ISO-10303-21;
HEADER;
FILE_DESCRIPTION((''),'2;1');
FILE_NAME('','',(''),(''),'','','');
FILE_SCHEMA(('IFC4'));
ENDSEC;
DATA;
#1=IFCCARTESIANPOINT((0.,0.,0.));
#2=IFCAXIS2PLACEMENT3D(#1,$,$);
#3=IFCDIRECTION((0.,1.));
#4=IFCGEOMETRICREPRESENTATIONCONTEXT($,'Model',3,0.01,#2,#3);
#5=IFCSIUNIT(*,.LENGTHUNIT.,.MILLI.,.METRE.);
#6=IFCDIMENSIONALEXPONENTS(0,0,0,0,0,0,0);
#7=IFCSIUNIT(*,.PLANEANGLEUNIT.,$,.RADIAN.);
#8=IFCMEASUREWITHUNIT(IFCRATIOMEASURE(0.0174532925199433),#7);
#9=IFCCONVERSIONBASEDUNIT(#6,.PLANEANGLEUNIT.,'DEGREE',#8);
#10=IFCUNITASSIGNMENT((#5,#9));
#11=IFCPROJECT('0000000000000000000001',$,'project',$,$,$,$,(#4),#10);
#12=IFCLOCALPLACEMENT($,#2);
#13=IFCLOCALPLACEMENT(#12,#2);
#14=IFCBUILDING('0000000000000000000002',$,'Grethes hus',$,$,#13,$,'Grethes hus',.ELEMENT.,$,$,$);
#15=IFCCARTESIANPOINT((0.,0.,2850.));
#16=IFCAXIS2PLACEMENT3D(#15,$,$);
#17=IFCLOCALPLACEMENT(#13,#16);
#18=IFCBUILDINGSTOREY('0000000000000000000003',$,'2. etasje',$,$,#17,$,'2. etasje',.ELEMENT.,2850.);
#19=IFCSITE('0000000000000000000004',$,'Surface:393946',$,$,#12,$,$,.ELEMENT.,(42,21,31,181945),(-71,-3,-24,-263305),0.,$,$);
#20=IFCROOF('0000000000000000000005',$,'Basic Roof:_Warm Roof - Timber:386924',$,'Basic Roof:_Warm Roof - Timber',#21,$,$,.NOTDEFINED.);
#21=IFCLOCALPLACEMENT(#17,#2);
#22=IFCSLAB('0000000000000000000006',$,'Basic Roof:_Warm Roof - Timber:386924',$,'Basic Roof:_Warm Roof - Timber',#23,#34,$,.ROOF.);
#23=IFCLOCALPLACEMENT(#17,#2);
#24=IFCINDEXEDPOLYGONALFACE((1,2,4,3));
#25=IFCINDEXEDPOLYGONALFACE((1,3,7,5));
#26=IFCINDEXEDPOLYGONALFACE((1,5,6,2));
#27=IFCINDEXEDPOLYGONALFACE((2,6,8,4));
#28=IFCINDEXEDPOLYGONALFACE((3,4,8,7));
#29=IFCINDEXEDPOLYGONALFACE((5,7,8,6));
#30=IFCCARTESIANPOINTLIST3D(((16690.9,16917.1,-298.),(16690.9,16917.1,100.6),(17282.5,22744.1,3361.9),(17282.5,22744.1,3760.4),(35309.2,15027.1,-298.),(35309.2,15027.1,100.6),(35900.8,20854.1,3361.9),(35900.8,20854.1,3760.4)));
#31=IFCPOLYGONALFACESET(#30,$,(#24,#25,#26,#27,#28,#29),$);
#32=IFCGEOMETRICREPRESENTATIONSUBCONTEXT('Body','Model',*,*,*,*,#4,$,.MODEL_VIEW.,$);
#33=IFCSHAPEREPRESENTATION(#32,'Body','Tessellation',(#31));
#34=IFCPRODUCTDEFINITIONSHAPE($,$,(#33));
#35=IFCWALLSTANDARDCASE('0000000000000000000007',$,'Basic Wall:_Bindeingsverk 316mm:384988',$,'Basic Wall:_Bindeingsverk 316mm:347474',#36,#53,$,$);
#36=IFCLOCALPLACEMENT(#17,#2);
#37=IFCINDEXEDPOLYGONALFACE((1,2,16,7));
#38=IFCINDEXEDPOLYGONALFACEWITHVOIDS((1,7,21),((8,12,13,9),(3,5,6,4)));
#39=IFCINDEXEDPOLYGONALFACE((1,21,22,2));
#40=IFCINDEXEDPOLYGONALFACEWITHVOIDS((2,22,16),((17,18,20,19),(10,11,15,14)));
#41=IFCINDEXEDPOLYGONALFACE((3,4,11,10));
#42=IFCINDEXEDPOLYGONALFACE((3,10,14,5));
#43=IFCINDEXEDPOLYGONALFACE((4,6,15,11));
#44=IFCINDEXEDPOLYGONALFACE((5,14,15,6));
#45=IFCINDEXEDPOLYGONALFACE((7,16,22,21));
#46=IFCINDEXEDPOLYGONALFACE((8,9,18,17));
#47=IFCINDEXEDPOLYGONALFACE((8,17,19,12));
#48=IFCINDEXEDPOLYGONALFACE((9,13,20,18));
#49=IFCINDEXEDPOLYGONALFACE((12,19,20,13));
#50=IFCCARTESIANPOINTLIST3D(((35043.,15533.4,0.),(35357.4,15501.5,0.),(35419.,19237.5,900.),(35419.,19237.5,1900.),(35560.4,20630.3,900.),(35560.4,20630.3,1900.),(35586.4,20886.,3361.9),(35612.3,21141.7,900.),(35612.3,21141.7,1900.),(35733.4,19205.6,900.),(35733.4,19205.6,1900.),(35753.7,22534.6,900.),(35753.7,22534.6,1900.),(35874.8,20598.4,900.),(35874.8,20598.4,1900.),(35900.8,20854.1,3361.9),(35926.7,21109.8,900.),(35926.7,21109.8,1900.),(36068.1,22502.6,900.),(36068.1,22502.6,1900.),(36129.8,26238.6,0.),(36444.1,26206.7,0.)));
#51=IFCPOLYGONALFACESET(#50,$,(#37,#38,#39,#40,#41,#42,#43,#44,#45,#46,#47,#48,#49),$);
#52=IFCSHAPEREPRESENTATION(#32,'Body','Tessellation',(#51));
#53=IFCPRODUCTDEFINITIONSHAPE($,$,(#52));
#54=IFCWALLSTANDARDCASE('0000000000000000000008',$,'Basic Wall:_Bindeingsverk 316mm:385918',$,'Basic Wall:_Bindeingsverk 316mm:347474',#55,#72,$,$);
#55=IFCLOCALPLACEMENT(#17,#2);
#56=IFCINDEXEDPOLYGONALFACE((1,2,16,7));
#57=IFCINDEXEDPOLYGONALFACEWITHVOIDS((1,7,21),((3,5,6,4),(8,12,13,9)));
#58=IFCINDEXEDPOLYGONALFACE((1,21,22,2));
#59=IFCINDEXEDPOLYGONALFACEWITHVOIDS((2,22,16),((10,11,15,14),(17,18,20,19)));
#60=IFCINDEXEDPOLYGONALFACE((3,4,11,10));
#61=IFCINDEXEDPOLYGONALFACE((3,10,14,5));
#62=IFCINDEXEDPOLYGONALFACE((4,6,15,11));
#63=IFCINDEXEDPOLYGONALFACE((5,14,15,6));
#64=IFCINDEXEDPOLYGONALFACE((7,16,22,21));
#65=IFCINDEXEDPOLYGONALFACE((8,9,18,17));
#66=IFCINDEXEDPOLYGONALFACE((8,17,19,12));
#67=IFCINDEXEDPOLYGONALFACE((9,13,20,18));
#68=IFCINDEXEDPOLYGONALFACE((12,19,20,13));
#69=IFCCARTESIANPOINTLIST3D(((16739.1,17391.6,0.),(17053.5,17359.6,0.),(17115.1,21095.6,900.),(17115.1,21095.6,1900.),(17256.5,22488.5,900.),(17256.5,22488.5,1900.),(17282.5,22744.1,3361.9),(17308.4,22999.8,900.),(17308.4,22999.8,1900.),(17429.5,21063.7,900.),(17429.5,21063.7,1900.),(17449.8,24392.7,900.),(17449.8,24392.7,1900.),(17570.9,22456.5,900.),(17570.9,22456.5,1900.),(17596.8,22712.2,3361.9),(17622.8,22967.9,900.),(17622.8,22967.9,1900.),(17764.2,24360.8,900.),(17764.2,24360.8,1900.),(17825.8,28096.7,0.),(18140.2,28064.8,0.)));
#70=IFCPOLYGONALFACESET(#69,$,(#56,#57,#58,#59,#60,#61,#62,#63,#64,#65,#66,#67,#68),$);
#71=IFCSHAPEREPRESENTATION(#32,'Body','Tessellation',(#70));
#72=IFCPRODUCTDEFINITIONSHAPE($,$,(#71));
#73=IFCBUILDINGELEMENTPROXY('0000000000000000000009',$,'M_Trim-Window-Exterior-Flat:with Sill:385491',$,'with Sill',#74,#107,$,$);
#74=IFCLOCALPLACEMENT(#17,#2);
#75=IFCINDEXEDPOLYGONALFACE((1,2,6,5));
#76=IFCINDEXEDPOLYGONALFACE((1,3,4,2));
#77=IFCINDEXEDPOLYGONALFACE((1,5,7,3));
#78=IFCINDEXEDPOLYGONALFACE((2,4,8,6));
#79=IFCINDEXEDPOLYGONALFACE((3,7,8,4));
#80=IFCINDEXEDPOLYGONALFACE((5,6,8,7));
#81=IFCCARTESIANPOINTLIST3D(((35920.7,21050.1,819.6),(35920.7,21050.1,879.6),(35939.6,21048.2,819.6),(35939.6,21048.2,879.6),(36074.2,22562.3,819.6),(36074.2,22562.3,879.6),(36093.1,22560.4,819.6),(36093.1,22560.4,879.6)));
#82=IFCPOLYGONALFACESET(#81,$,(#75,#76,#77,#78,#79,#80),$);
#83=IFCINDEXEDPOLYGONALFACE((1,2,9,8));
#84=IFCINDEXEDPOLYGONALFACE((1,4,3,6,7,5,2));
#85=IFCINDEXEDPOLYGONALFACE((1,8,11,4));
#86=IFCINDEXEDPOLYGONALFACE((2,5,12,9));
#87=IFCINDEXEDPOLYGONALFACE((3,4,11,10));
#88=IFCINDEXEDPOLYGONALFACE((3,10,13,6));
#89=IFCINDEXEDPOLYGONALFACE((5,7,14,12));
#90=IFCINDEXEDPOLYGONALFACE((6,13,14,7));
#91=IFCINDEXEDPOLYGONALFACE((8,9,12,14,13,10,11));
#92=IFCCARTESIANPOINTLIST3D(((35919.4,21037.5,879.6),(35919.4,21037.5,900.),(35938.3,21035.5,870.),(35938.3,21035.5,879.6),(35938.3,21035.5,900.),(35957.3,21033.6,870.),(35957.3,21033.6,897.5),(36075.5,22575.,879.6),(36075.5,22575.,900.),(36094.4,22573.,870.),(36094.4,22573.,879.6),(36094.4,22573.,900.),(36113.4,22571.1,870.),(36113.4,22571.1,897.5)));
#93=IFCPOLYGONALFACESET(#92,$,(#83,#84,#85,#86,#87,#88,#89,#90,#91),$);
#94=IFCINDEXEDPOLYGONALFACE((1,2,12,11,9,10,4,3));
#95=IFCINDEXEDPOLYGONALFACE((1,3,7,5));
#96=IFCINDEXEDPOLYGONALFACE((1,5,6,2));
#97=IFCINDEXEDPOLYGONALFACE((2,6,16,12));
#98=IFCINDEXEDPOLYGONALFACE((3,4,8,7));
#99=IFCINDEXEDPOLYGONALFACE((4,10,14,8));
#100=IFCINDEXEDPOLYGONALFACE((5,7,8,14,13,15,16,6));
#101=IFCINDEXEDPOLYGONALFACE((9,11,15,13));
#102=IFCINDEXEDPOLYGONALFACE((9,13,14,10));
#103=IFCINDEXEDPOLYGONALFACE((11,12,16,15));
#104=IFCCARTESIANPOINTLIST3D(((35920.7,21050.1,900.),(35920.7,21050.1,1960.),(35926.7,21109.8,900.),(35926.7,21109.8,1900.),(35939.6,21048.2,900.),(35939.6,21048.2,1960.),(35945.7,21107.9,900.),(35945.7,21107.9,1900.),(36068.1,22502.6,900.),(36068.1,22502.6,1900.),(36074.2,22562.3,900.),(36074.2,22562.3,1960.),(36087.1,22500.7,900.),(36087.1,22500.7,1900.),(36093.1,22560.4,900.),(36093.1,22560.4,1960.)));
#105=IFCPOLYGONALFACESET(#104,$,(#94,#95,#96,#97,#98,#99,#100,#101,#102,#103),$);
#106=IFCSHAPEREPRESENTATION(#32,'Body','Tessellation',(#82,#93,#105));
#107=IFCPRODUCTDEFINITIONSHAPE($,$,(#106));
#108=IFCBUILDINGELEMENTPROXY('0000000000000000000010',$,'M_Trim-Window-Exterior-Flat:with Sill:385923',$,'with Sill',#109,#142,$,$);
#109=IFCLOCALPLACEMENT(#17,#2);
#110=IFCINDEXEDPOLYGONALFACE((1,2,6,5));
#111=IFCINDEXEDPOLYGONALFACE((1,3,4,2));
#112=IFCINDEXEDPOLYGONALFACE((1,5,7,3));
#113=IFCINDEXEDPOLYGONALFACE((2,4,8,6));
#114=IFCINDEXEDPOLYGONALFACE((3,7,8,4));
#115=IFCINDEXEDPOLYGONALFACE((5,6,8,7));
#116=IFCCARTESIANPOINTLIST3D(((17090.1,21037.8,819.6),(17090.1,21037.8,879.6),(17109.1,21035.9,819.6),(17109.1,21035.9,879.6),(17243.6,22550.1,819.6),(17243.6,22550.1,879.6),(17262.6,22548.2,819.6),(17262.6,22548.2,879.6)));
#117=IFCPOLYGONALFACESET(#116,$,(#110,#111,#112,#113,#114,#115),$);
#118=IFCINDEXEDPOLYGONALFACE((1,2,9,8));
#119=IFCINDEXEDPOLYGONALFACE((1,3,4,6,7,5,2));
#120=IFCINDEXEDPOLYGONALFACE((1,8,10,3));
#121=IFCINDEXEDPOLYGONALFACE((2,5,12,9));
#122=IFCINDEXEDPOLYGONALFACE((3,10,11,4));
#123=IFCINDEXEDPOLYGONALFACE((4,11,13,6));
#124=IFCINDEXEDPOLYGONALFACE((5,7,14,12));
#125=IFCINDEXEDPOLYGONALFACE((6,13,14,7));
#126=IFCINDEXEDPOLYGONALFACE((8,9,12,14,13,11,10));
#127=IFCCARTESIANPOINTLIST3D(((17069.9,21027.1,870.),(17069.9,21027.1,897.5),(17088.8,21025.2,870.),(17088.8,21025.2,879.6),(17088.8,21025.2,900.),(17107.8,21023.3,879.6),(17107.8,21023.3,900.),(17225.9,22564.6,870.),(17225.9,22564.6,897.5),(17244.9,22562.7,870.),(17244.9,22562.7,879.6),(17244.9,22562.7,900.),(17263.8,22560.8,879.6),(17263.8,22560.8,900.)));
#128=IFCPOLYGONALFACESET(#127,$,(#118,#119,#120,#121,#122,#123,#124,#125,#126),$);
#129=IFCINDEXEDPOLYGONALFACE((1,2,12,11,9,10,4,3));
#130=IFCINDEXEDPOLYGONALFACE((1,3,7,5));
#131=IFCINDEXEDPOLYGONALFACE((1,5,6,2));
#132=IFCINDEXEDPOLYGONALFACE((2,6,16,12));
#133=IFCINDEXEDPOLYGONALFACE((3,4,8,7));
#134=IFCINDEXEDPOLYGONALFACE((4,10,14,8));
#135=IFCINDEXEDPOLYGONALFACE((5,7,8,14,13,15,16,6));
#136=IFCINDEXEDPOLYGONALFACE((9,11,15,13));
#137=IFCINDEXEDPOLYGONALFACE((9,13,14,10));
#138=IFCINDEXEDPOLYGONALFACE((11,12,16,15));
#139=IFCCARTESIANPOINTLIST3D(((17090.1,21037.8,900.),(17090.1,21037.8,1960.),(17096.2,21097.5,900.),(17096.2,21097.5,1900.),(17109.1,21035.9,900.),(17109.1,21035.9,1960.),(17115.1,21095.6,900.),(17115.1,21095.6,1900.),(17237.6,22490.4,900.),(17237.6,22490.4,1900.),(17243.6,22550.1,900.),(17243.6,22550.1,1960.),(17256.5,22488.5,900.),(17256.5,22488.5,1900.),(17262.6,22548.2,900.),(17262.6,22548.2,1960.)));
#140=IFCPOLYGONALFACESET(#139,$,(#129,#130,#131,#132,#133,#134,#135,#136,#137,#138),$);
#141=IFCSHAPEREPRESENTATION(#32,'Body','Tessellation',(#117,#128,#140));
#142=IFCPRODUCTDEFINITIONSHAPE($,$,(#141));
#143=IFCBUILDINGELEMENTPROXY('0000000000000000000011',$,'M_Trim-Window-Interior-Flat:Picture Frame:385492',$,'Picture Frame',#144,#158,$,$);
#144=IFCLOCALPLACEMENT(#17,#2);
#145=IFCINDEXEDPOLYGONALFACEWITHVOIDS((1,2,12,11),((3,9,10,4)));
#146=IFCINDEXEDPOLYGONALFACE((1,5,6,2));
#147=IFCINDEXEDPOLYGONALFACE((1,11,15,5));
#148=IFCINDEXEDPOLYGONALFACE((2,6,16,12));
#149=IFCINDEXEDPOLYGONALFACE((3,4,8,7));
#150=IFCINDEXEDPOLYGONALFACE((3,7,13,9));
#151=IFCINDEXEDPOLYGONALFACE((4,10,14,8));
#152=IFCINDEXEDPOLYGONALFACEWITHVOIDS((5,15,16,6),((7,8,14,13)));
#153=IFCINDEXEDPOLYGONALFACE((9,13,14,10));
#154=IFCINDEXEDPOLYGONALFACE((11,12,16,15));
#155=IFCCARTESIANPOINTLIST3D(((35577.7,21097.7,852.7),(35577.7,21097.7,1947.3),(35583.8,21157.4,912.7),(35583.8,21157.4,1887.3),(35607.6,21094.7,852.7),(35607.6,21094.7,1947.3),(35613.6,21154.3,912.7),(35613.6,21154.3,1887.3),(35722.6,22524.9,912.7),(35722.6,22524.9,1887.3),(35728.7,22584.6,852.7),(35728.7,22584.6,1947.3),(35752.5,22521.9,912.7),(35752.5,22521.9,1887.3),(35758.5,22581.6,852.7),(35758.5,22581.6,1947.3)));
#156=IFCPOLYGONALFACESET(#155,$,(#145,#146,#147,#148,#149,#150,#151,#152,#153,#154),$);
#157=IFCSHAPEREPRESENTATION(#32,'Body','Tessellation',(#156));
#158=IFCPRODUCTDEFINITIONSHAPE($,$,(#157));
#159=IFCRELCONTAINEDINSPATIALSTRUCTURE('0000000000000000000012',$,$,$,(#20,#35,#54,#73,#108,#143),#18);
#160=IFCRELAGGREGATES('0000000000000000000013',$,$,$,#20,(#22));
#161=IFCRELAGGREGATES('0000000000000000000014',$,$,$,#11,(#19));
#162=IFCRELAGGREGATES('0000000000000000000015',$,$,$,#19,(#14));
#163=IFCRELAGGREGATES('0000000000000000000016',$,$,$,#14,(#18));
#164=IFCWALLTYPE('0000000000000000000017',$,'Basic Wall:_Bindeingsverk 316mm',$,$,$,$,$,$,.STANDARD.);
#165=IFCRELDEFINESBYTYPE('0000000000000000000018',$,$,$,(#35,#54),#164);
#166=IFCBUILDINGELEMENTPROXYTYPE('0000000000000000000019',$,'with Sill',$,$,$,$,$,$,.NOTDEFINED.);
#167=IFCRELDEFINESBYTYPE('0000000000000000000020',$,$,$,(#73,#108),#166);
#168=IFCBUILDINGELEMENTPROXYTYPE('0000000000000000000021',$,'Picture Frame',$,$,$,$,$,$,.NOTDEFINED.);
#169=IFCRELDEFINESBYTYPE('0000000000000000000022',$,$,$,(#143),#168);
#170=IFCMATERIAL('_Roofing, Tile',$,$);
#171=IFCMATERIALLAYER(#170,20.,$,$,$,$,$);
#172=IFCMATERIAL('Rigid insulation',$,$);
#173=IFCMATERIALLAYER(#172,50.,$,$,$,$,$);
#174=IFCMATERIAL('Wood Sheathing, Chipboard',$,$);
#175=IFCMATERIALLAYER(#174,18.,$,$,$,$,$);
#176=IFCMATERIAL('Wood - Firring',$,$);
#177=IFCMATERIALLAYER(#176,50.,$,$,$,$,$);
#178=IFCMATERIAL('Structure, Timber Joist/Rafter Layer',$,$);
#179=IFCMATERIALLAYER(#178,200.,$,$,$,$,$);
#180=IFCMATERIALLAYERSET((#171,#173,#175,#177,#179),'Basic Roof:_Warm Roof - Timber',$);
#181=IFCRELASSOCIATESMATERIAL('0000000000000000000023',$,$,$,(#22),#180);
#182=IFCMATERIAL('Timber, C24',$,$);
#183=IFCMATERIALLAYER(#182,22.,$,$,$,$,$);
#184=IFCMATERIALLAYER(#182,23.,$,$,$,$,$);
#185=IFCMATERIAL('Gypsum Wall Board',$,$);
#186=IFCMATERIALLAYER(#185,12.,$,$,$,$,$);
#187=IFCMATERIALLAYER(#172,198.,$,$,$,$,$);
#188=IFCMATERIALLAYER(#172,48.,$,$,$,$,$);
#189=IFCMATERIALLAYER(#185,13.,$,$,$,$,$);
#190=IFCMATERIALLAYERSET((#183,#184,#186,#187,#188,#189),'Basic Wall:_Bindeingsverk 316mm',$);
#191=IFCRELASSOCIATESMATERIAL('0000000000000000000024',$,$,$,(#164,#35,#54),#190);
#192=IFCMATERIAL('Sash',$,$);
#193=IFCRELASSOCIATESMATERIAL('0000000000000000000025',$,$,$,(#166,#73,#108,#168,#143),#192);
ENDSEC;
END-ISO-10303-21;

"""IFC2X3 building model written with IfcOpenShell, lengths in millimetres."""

from ifc_helpers import new_model, entity, si_unit, converted_unit, direction, frame, frame_2d, origin, place, context, subcontext, project, spatial, polyline, rectangle, outline, extrude, clip, halfspace, source, transform, mapped, material, layer, layer_set, layer_usage, type_object, type_shapes, element, aggregate, save


model = new_model("IFC2X3")

# Units and contexts
model_context = context("Model", 3, precision=0.01, world=origin(), true_north=direction((0.0, 1.0)))
body_context = subcontext(model_context, "Body", "Model", "MODEL_VIEW")
ifc_project = project(units=[si_unit("LENGTHUNIT", "METRE", prefix="MILLI"), converted_unit("PLANEANGLEUNIT", "DEGREE", entity("IfcRatioMeasure", 0.0174532925199433), si_unit("PLANEANGLEUNIT", "RADIAN"), dimensions=[0, 0, 0, 0, 0, 0, 0])], contexts=[model_context])

# Site, building, storey
site_placement = place(None, origin())
site = spatial("IfcSite", under=ifc_project, at=site_placement, Name="Surface:393946", CompositionType="ELEMENT", RefLatitude=(42, 21, 31, 181945), RefLongitude=(-71, -3, -24, -263305), RefElevation=0.0)
building_placement = place(site_placement, origin())
building = spatial("IfcBuilding", under=site, at=building_placement, Name="Grethes hus", LongName="Grethes hus", CompositionType="ELEMENT")
storey_placement = place(building_placement, frame((0.0, 0.0, 2850.0)))
storey = spatial("IfcBuildingStorey", under=building, at=storey_placement, Name="2. etasje", LongName="2. etasje", CompositionType="ELEMENT", Elevation=2850.0)

# Shared definitions
ifc_material_1 = material(Name="Wood Sheathing, Chipboard")
ifc_material_2 = material(Name="Structure, Timber Joist/Rafter Layer")

# Roof, slab
roof_placement = place(storey_placement, frame((16690.9, 15027.1, -298.0)))
roof = element("IfcRoof", 1, at=roof_placement, inside=storey, Name="Basic Roof:_Warm Roof - Timber:386924", ObjectType="Basic Roof:_Warm Roof - Timber", ShapeType="NOTDEFINED")
ifc_material_3 = material(Name="_Roofing, Tile")
ifc_layer_1 = layer(ifc_material_3, 20.0)
ifc_material_4 = material(Name="Rigid insulation")
ifc_layer_2 = layer(ifc_material_4, 50.0)
ifc_layer_3 = layer(ifc_material_1, 18.0)
ifc_material_5 = material(Name="Wood - Firring")
ifc_layer_4 = layer(ifc_material_5, 50.0)
ifc_layer_5 = layer(ifc_material_2, 200.0)
ifc_layer_set_1 = layer_set([ifc_layer_1, ifc_layer_2, ifc_layer_3, ifc_layer_4, ifc_layer_5], Name="Basic Roof:_Warm Roof - Timber")
slab_1_placement = place(roof_placement, origin())
slab_1 = element("IfcSlab", 2, at=slab_1_placement, material=ifc_layer_set_1, Name="Basic Roof:_Warm Roof - Timber:386924", ObjectType="Basic Roof:_Warm Roof - Timber", PredefinedType="ROOF", context=body_context, shape_type="SweptSolid", body=[
    extrude(rectangle(XDim=6906.4, YDim=18714.0, at=frame_2d((0.0, 0.0), x_axis=(0.085772, 0.996315))), frame((9604.9, 3858.5, 1829.9), z_axis=(-0.05352, -0.52721, 0.848048), x_axis=(0.998567, -0.028257, 0.045452)), (0.045452, 0.527966, 0.848048), 398.6),
])
aggregate(roof, [slab_1])

# Walls, openings
ifc_material_6 = material(Name="Timber, C24")
ifc_layer_6 = layer(ifc_material_6, 22.0)
ifc_layer_7 = layer(ifc_material_6, 23.0)
ifc_material_7 = material(Name="Gypsum Wall Board")
ifc_layer_8 = layer(ifc_material_7, 12.0)
ifc_layer_9 = layer(ifc_material_4, 198.0)
ifc_layer_10 = layer(ifc_material_4, 48.0)
ifc_layer_11 = layer(ifc_material_7, 13.0)
ifc_layer_set_2 = layer_set([ifc_layer_6, ifc_layer_7, ifc_layer_8, ifc_layer_9, ifc_layer_10, ifc_layer_11], Name="Basic Wall:_Bindeingsverk 316mm")
ifc_layer_usage_1 = layer_usage(ifc_layer_set_2, "AXIS2", "NEGATIVE", 158.0)
wall_type = type_object("IfcWallType", Name="Basic Wall:_Bindeingsverk 316mm", PredefinedType="STANDARD", material=ifc_layer_set_2)
wall_1_placement = place(storey_placement, frame((36287.0, 26222.7, 0.0), z_axis=(0.0, 0.0, 1.0), x_axis=(-0.100996, -0.994887, 0.0)))
wall_1 = element("IfcWallStandardCase", 3, at=wall_1_placement, inside=storey, type_object=wall_type, material=ifc_layer_usage_1, Name="Basic Wall:_Bindeingsverk 316mm:384988", ObjectType="Basic Wall:_Bindeingsverk 316mm:347474", context=body_context, shape_type="Clipping", body=[
    clip(clip(extrude(rectangle(XDim=10760.2, YDim=316.0, at=frame_2d((5380.1, 0.0), x_axis=(-1.0, 0.0))), origin(), (0.0, 0.0, 1.0), 3361.9), halfspace(frame((5380.1, -158.0, 3361.9), z_axis=(0.529919, 0.0, 0.848048), x_axis=(0.0, 1.0, 0.0)), False)), halfspace(frame((0.0, -158.0, 0.0), z_axis=(-0.529919, 0.0, 0.848048), x_axis=(0.0, 1.0, 0.0)), False)),
])
opening_1_placement = place(wall_1_placement, frame((3723.1, -158.0, 900.0)))
element("IfcOpeningElement", 4, at=opening_1_placement, cuts=wall_1, ObjectType="Opening", context=body_context, shape_type="SweptSolid", body=[
    extrude(rectangle(XDim=1000.0, YDim=1400.0, at=frame_2d((500.0, 700.0), x_axis=(-1.0, 0.0))), frame((0.0, 0.0, 0.0), z_axis=(0.0, 1.0, 0.0), x_axis=(0.0, 0.0, 1.0)), (0.0, 0.0, 1.0), 316.0),
])
opening_2_placement = place(wall_1_placement, frame((5637.1, -158.0, 900.0)))
element("IfcOpeningElement", 5, at=opening_2_placement, cuts=wall_1, ObjectType="Opening", context=body_context, shape_type="SweptSolid", body=[
    extrude(rectangle(XDim=1000.0, YDim=1400.0, at=frame_2d((500.0, 700.0), x_axis=(-1.0, 0.0))), frame((0.0, 0.0, 0.0), z_axis=(0.0, 1.0, 0.0), x_axis=(0.0, 0.0, 1.0)), (0.0, 0.0, 1.0), 316.0),
])
ifc_layer_usage_2 = layer_usage(ifc_layer_set_2, "AXIS2", "POSITIVE", -158.0)
wall_2_placement = place(storey_placement, frame((17983.0, 28080.8, 0.0), z_axis=(0.0, 0.0, 1.0), x_axis=(-0.100996, -0.994887, 0.0)))
wall_2 = element("IfcWallStandardCase", 6, at=wall_2_placement, inside=storey, type_object=wall_type, material=ifc_layer_usage_2, Name="Basic Wall:_Bindeingsverk 316mm:385918", ObjectType="Basic Wall:_Bindeingsverk 316mm:347474", context=body_context, shape_type="Clipping", body=[
    clip(clip(extrude(rectangle(XDim=10760.2, YDim=316.0, at=frame_2d((5380.1, 0.0), x_axis=(-1.0, 0.0))), origin(), (0.0, 0.0, 1.0), 3361.9), halfspace(frame((0.0, -158.0, 0.0), z_axis=(-0.529919, 0.0, 0.848048), x_axis=(0.0, 1.0, 0.0)), False)), halfspace(frame((5380.1, -158.0, 3361.9), z_axis=(0.529919, 0.0, 0.848048), x_axis=(0.0, 1.0, 0.0)), False)),
])
opening_3_placement = place(wall_2_placement, frame((5123.1, 158.0, 900.0)))
element("IfcOpeningElement", 7, at=opening_3_placement, cuts=wall_2, ObjectType="Opening", context=body_context, shape_type="SweptSolid", body=[
    extrude(rectangle(XDim=1000.0, YDim=1400.0, at=frame_2d((500.0, 700.0), x_axis=(-1.0, 0.0))), frame((0.0, 0.0, 0.0), z_axis=(0.0, -1.0, 0.0), x_axis=(0.0, 0.0, 1.0)), (0.0, 0.0, 1.0), 316.0),
])
opening_4_placement = place(wall_2_placement, frame((7037.1, 158.0, 900.0)))
element("IfcOpeningElement", 8, at=opening_4_placement, cuts=wall_2, ObjectType="Opening", context=body_context, shape_type="SweptSolid", body=[
    extrude(rectangle(XDim=1000.0, YDim=1400.0, at=frame_2d((500.0, 700.0), x_axis=(-1.0, 0.0))), frame((0.0, 0.0, 0.0), z_axis=(0.0, -1.0, 0.0), x_axis=(0.0, 0.0, 1.0)), (0.0, 0.0, 1.0), 316.0),
])

# Building element proxies
ifc_material_8 = material(Name="Sash")
building_element_proxy_type_1 = type_object("IfcBuildingElementProxyType", Name="with Sill", PredefinedType="NOTDEFINED", material=ifc_material_8)
shared_shape_1 = source(origin(), body_context, "Body", "SweptSolid", [
    extrude(rectangle(XDim=1520.0, YDim=60.0, at=frame_2d((0.0, 0.0), x_axis=(1.0, 0.0))), frame((0.0, -1050.4, 0.0), z_axis=(0.0, 0.0, 1.0), x_axis=(-1.0, 0.0, 0.0)), (0.0, 0.0, 1.0), 19.1),
    extrude(outline(polyline([(-19.0, -15.2), (0.0, -15.2), (0.0, -5.7), (19.0, -5.7), (19.0, 14.8), (0.0, 14.8), (-19.0, 12.3), (-19.0, -15.2)])), frame((-772.7, -1014.8, 19.0), z_axis=(1.0, 0.0, 0.0), x_axis=(0.0, 0.0, -1.0)), (0.0, 0.0, 1.0), 1545.4),
    extrude(outline(polyline([(-545.0, -760.0), (515.0, -760.0), (515.0, -700.0), (-485.0, -700.0), (-485.0, 700.0), (515.0, 700.0), (515.0, 760.0), (-545.0, 760.0), (-545.0, -760.0)])), frame((0.0, -485.0, 0.0), z_axis=(0.0, 0.0, 1.0), x_axis=(0.0, -1.0, 0.0)), (0.0, 0.0, 1.0), 19.1),
])
type_shapes(building_element_proxy_type_1, [shared_shape_1])
for number, where, z_axis, x_axis, name in (
    (9, (35997.4, 21806.2, 1900.0), (0.994887, -0.100996, 0.0), (0.100996, 0.994887, 0.0), "M_Trim-Window-Exterior-Flat:with Sill:385491"),
    (10, (17185.8, 21792.0, 1900.0), (-0.994887, 0.100996, 0.0), (-0.100996, -0.994887, 0.0), "M_Trim-Window-Exterior-Flat:with Sill:385923"),
):
    element("IfcBuildingElementProxy", number, at=place(storey_placement, frame(where, z_axis=z_axis, x_axis=x_axis)), inside=storey, type_object=building_element_proxy_type_1, material=ifc_material_8, Name=name, ObjectType="with Sill", context=body_context, shape_type="MappedRepresentation", body=[
        mapped(shared_shape_1, transform((0.0, 0.0, 0.0), scale=1.0)),
    ])
building_element_proxy_type_2 = type_object("IfcBuildingElementProxyType", Name="Picture Frame", PredefinedType="NOTDEFINED", material=ifc_material_8)
shared_shape_2 = source(origin(), body_context, "Body", "SweptSolid", [
    extrude(outline(polyline([(-747.3, -547.3), (747.3, -547.3), (747.3, 547.3), (-747.3, 547.3), (-747.3, -547.3)]), holes=[polyline([(-687.3, -487.3), (-687.3, 487.3), (687.3, 487.3), (687.3, -487.3), (-687.3, -487.3)])]), frame((0.0, -500.0, 0.0), z_axis=(0.0, 0.0, 1.0), x_axis=(-1.0, 0.0, 0.0)), (0.0, 0.0, 1.0), 30.0),
])
type_shapes(building_element_proxy_type_2, [shared_shape_2])
for number, where, z_axis, x_axis, name in (
    (11, (35683.0, 21838.1, 1900.0), (-0.994887, 0.100996, 0.0), (-0.100996, -0.994887, 0.0), "M_Trim-Window-Interior-Flat:Picture Frame:385492"),
):
    element("IfcBuildingElementProxy", number, at=place(storey_placement, frame(where, z_axis=z_axis, x_axis=x_axis)), inside=storey, type_object=building_element_proxy_type_2, material=ifc_material_8, Name=name, ObjectType="Picture Frame", context=body_context, shape_type="MappedRepresentation", body=[
        mapped(shared_shape_2, transform((0.0, 0.0, 0.0), scale=1.0)),
    ])

save(model, "model.ifc")
